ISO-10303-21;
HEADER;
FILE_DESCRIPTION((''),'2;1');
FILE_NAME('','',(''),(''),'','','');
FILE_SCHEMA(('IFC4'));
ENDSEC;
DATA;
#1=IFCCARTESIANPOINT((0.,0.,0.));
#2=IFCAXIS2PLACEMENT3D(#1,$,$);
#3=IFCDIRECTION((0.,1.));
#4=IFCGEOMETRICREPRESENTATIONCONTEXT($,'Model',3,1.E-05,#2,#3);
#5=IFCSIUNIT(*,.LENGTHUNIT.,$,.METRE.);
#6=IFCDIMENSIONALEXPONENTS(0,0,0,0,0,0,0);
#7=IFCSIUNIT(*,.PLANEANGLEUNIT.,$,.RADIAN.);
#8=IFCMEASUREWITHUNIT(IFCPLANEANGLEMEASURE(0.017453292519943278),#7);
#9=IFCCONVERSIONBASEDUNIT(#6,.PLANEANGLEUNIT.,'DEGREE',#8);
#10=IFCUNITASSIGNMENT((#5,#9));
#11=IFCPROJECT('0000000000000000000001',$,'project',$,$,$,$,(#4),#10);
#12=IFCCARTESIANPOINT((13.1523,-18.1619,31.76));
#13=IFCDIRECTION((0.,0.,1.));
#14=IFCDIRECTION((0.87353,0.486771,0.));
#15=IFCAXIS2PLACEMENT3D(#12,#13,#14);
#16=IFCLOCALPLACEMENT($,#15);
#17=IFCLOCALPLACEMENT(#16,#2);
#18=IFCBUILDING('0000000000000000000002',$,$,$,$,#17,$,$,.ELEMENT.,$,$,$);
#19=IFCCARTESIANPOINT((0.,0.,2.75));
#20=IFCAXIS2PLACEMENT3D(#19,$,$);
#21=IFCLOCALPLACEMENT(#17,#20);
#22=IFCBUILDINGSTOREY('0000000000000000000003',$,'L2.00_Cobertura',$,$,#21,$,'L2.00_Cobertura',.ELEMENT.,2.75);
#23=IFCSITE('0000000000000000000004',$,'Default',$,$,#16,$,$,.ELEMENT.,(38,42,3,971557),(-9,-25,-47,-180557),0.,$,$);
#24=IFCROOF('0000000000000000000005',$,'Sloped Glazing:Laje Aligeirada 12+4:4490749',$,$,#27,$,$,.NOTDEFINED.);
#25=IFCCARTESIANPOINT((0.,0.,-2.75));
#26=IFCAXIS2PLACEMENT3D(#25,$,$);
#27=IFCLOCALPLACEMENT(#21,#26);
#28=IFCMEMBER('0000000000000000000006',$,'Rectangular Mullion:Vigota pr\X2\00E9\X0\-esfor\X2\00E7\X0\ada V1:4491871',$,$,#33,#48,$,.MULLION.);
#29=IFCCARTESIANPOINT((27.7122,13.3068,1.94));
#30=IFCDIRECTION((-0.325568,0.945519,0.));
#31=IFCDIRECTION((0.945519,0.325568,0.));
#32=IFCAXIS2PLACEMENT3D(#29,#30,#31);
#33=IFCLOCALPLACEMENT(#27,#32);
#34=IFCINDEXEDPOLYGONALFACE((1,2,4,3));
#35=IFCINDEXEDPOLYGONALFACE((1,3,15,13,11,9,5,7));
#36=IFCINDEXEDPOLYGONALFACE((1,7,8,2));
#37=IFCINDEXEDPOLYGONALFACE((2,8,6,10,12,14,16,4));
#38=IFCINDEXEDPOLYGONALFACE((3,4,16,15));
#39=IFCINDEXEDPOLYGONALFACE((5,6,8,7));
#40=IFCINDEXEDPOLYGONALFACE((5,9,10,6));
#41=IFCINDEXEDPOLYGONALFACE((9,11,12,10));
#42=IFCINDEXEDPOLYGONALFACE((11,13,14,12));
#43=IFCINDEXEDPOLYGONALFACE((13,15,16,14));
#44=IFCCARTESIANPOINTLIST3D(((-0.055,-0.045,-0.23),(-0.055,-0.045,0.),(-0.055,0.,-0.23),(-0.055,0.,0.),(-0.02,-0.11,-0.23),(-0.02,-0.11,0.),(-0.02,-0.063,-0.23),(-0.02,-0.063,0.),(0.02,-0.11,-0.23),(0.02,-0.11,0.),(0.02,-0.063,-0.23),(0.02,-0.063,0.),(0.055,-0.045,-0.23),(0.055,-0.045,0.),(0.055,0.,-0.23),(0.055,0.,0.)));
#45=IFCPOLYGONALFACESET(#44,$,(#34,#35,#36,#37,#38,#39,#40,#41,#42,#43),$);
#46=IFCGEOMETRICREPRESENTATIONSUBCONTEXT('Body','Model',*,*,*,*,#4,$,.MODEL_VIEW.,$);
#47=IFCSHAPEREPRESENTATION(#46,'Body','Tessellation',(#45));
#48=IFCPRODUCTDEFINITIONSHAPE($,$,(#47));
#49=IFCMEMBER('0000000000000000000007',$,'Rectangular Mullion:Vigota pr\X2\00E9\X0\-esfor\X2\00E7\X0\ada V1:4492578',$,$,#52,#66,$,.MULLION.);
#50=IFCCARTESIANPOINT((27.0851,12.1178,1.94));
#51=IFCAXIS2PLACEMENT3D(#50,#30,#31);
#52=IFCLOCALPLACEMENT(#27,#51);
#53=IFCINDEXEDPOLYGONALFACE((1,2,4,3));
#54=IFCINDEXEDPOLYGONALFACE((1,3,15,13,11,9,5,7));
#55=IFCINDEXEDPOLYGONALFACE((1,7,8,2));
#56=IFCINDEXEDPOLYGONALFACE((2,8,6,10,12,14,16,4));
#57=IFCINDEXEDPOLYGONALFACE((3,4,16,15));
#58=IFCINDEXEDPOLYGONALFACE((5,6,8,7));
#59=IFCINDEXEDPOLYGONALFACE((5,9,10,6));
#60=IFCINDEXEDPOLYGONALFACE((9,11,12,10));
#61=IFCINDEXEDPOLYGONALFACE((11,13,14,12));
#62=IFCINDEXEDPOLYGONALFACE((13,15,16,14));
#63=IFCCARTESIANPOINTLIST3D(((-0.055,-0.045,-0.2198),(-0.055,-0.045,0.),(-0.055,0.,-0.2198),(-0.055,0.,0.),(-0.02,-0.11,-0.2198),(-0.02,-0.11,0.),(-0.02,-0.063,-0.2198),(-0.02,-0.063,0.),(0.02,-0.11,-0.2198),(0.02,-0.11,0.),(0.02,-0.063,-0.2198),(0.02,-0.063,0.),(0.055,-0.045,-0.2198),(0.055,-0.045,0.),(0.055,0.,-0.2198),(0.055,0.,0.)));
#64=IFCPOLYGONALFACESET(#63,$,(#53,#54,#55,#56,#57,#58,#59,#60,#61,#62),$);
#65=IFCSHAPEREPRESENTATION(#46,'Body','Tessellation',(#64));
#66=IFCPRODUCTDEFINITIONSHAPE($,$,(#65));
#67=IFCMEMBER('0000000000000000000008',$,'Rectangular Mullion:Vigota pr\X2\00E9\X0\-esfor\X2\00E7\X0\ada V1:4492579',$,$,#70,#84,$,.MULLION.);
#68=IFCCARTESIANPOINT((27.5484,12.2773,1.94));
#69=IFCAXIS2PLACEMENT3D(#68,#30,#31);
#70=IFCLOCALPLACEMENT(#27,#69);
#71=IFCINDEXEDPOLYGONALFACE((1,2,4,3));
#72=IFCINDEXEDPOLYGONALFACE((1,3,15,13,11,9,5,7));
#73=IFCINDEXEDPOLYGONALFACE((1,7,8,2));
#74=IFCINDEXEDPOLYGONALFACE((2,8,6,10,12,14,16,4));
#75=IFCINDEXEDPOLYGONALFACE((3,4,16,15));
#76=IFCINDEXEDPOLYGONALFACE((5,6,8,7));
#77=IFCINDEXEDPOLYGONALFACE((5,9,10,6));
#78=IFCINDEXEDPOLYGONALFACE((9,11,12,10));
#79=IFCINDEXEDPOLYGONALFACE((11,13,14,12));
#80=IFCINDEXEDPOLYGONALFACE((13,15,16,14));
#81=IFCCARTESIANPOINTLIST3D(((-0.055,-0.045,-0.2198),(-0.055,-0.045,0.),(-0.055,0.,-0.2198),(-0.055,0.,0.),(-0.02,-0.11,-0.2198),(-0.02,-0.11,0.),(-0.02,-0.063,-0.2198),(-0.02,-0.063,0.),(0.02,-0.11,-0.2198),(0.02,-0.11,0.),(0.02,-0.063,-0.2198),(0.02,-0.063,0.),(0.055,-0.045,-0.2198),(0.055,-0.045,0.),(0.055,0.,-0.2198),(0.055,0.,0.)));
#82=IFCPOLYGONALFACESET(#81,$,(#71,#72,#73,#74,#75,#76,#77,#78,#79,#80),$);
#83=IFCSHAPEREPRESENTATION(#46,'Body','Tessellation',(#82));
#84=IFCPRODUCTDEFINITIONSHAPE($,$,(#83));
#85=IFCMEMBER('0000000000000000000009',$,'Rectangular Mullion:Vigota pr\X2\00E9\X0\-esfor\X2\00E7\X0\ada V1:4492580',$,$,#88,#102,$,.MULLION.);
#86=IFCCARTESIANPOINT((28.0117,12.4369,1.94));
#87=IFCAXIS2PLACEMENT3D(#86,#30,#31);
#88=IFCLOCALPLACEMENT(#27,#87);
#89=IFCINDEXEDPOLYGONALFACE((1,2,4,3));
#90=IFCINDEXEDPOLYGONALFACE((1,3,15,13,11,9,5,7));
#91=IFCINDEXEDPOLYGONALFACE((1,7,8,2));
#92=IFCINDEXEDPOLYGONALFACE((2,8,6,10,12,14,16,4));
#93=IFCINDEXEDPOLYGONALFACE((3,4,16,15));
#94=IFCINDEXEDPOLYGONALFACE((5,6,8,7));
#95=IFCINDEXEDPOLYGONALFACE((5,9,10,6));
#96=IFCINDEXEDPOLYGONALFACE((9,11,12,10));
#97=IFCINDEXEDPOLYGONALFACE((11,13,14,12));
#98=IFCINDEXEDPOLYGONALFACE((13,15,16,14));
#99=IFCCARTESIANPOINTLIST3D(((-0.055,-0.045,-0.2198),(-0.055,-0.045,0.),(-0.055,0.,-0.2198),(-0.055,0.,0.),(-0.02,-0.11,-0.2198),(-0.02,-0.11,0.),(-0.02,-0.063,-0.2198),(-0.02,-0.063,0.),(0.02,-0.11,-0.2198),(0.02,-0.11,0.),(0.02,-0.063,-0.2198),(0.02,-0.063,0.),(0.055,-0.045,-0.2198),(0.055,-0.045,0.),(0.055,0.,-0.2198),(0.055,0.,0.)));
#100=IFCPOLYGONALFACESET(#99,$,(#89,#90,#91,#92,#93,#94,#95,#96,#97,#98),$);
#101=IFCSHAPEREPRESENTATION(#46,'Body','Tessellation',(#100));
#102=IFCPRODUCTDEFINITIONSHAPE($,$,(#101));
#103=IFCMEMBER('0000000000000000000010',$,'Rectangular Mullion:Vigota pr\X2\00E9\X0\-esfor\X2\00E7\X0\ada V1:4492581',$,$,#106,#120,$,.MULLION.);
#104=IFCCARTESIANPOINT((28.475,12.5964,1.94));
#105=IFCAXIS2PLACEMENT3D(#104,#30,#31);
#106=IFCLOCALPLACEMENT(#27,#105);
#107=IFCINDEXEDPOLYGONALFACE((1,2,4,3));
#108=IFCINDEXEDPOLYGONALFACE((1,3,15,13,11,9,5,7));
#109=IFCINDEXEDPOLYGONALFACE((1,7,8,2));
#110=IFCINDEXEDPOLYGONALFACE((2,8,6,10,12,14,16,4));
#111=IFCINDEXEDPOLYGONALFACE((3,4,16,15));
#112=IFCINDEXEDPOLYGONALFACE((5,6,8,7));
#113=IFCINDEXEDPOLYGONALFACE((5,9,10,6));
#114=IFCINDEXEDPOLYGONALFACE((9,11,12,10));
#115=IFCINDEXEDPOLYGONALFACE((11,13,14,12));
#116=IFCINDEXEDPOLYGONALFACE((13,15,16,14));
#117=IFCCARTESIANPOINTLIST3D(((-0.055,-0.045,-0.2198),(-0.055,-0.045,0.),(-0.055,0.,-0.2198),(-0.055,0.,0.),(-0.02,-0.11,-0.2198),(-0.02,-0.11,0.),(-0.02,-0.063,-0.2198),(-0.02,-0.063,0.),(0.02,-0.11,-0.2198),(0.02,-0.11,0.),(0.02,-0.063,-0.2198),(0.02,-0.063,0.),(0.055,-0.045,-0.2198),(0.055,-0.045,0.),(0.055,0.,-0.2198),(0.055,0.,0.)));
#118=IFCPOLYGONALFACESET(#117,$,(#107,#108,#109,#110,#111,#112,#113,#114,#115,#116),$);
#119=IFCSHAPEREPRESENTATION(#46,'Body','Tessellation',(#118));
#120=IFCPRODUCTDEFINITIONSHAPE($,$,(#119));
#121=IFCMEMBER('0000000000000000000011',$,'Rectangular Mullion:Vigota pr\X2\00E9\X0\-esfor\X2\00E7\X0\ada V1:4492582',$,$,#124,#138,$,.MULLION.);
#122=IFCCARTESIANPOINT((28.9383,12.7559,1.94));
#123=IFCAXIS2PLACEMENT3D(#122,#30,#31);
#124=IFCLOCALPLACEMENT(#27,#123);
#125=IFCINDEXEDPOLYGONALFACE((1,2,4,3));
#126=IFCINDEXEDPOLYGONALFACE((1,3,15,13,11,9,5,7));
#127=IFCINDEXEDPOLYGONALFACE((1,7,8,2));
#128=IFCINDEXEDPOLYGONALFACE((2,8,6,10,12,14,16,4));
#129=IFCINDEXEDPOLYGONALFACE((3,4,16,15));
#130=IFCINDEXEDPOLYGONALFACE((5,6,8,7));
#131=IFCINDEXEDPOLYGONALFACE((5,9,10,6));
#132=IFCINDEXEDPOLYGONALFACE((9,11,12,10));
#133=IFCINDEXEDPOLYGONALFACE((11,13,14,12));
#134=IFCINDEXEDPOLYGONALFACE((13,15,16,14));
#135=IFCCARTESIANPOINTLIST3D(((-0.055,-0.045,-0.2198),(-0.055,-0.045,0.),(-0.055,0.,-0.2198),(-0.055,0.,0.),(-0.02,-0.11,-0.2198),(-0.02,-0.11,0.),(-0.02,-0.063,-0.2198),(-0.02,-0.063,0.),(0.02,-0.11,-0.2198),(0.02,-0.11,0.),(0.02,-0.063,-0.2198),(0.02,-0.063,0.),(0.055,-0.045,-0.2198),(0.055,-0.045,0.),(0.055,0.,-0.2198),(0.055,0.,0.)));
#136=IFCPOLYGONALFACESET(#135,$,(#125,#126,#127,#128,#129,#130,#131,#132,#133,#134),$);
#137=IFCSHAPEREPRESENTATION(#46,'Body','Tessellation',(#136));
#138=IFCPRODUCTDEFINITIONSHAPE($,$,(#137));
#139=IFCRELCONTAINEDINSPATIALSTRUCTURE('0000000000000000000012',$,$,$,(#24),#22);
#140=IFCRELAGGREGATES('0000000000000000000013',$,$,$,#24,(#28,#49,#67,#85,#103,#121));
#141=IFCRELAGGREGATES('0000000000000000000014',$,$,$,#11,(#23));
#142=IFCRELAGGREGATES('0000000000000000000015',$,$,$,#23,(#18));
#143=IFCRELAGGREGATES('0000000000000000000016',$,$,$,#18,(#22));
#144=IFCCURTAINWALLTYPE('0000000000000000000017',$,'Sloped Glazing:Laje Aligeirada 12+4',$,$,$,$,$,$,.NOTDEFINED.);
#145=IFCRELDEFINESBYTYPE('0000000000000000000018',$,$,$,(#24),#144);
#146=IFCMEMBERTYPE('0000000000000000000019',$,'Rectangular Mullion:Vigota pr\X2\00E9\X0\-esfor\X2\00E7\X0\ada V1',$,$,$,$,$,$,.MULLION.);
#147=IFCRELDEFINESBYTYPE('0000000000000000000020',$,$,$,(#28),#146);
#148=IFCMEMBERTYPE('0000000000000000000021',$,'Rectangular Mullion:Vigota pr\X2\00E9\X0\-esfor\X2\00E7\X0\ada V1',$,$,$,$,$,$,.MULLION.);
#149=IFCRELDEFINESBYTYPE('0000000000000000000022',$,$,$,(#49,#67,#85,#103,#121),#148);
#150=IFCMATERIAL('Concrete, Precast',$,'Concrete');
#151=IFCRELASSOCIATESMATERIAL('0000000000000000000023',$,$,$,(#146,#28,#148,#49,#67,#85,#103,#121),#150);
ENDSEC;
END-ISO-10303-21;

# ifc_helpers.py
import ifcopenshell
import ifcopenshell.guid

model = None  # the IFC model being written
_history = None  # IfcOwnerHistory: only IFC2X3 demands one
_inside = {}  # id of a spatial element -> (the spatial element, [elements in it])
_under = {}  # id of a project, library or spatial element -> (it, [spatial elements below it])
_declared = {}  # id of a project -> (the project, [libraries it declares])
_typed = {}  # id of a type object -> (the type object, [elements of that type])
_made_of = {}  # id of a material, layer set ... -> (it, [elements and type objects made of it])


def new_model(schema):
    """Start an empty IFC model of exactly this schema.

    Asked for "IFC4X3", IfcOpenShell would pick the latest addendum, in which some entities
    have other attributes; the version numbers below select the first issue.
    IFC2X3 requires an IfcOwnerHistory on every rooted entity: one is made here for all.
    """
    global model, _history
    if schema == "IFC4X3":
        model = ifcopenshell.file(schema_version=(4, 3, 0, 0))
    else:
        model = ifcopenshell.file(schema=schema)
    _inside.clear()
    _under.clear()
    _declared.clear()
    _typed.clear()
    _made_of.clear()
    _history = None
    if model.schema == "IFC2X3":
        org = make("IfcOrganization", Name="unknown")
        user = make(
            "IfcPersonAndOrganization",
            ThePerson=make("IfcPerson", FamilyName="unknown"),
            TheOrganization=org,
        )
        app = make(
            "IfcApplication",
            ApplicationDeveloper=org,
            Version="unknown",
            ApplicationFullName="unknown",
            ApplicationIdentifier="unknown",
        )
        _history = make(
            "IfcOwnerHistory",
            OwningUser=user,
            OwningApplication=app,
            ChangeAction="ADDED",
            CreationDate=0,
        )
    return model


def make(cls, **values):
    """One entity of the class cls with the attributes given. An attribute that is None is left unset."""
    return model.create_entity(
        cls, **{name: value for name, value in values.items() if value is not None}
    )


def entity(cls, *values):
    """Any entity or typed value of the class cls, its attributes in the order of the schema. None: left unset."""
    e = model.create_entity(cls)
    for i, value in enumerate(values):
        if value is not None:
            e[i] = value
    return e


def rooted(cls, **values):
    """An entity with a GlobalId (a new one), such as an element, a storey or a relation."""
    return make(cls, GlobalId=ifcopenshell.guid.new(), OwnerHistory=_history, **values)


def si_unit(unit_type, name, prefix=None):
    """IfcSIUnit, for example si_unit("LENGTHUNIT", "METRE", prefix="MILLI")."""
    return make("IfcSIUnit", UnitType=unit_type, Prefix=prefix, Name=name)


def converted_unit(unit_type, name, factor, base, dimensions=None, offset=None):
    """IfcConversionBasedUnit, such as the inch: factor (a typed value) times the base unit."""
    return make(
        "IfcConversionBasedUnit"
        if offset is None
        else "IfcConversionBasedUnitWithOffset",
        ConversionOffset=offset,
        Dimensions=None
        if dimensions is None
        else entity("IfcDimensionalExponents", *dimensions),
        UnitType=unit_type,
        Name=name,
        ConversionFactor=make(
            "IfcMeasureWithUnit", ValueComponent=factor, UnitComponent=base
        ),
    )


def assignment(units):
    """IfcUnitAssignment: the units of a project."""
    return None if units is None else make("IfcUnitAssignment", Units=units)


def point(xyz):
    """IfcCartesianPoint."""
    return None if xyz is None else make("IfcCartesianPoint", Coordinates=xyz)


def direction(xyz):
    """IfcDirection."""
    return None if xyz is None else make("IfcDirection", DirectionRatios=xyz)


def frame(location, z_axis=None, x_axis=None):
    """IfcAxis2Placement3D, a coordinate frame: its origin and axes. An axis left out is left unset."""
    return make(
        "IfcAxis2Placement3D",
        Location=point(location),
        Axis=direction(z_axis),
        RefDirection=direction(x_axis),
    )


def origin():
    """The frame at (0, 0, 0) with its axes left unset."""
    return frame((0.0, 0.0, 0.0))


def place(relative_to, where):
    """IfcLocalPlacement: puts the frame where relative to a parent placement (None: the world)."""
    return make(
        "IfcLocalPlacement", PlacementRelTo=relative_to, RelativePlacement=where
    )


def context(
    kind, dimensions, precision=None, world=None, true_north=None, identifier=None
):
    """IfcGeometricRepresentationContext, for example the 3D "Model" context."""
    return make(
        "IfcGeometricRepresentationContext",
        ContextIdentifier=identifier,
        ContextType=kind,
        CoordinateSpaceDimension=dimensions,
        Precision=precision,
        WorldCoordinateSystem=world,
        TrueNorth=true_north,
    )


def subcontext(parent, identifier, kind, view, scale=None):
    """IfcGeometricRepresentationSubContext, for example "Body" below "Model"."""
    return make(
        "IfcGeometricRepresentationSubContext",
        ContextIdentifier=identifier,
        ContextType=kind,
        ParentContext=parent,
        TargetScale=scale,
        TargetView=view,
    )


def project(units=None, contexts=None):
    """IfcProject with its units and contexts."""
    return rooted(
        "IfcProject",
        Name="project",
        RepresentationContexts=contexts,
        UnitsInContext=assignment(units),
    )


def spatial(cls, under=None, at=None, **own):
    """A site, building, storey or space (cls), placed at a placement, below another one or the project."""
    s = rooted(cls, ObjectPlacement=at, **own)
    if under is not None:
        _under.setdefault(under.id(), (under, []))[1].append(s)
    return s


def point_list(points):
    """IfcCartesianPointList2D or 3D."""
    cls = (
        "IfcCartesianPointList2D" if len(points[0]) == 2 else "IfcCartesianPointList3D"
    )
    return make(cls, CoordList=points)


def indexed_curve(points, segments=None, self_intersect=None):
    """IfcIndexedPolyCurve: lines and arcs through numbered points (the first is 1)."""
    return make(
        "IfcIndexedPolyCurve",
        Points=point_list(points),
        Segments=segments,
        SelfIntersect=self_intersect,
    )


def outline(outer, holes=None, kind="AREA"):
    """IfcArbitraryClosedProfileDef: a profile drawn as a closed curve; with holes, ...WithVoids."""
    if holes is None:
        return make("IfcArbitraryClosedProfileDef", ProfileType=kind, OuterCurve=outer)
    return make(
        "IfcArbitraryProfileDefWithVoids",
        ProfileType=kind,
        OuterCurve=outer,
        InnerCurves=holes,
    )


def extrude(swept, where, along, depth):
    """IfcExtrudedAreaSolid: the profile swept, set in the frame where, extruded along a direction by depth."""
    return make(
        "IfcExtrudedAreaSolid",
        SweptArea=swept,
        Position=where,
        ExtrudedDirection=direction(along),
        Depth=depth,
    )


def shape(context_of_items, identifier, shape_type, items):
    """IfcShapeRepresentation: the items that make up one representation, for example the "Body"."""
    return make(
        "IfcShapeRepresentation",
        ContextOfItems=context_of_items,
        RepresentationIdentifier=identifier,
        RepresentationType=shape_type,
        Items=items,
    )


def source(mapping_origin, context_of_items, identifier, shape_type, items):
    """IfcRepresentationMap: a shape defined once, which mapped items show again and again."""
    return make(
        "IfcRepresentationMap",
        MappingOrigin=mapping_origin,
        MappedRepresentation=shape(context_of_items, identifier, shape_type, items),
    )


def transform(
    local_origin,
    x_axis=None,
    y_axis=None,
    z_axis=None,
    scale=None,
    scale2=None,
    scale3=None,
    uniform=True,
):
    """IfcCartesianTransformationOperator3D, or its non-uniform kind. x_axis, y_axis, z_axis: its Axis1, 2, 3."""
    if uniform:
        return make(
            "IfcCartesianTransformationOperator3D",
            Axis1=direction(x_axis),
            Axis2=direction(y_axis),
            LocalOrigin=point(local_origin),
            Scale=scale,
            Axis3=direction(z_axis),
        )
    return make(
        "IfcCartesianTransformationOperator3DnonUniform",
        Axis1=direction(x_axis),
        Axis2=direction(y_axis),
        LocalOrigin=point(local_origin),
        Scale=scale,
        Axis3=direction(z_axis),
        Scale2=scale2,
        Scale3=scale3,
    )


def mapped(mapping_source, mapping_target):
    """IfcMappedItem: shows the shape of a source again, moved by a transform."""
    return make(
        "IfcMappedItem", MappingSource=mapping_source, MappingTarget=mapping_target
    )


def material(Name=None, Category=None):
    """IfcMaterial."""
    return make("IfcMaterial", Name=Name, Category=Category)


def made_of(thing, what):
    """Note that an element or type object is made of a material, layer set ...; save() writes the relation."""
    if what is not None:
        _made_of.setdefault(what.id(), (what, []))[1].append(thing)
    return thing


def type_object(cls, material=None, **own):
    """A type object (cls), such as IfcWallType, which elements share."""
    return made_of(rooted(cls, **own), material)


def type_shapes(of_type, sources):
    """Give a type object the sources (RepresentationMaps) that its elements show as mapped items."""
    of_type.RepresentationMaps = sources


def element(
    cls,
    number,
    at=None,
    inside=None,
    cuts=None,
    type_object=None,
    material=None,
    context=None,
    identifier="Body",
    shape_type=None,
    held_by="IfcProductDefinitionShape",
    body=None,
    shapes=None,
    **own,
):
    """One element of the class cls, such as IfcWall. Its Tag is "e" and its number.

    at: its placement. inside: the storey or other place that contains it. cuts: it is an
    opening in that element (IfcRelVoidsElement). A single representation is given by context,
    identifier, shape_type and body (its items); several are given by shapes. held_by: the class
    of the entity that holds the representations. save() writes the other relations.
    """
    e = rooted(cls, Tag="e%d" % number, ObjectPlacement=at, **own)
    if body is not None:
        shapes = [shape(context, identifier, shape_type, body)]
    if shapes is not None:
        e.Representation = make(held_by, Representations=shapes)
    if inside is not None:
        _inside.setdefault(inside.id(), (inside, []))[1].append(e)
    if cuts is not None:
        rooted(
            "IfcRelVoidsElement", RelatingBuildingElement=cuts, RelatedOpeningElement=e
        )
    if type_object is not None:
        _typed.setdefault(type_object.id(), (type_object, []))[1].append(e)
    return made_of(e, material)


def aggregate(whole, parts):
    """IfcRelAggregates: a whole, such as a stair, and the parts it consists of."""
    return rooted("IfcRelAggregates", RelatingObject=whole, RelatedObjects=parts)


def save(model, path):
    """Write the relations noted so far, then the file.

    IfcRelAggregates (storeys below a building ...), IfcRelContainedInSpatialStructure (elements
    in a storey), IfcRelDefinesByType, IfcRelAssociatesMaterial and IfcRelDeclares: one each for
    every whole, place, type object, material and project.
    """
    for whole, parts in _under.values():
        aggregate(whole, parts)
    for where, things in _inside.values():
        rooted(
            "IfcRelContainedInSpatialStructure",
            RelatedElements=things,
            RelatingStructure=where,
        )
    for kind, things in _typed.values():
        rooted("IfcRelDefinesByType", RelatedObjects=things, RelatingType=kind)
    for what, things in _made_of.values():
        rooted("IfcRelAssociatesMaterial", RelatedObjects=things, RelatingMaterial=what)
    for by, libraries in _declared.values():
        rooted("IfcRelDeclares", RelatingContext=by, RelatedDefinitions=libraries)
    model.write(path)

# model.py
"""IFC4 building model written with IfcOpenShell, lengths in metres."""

from ifc_helpers import new_model, entity, si_unit, converted_unit, direction, frame, origin, place, context, subcontext, project, spatial, indexed_curve, outline, extrude, source, transform, mapped, material, type_object, type_shapes, element, aggregate, save


model = new_model("IFC4")

# Units and contexts
model_context = context("Model", 3, precision=1e-05, world=origin(), true_north=direction((0.0, 1.0)))
body_context = subcontext(model_context, "Body", "Model", "MODEL_VIEW")
ifc_project = project(units=[si_unit("LENGTHUNIT", "METRE"), converted_unit("PLANEANGLEUNIT", "DEGREE", entity("IfcPlaneAngleMeasure", 0.017453292519943278), si_unit("PLANEANGLEUNIT", "RADIAN"), dimensions=[0, 0, 0, 0, 0, 0, 0])], contexts=[model_context])

# Site, building, storey
site_placement = place(None, frame((13.1523, -18.1619, 31.76), z_axis=(0.0, 0.0, 1.0), x_axis=(0.87353, 0.486771, 0.0)))
site = spatial("IfcSite", under=ifc_project, at=site_placement, Name="Default", CompositionType="ELEMENT", RefLatitude=(38, 42, 3, 971557), RefLongitude=(-9, -25, -47, -180557), RefElevation=0.0)
building_placement = place(site_placement, origin())
building = spatial("IfcBuilding", under=site, at=building_placement, CompositionType="ELEMENT")
storey_placement = place(building_placement, frame((0.0, 0.0, 2.75)))
storey = spatial("IfcBuildingStorey", under=building, at=storey_placement, Name="L2.00_Cobertura", LongName="L2.00_Cobertura", CompositionType="ELEMENT", Elevation=2.75)

# Roof, members
curtain_wall_type = type_object("IfcCurtainWallType", Name="Sloped Glazing:Laje Aligeirada 12+4", PredefinedType="NOTDEFINED")
roof_placement = place(storey_placement, frame((0.0, 0.0, -2.75)))
roof = element("IfcRoof", 1, at=roof_placement, inside=storey, type_object=curtain_wall_type, Name="Sloped Glazing:Laje Aligeirada 12+4:4490749", PredefinedType="NOTDEFINED")
ifc_material_1 = material(Name="Concrete, Precast", Category="Concrete")
member_type_1 = type_object("IfcMemberType", Name="Rectangular Mullion:Vigota pré-esforçada V1", PredefinedType="MULLION", material=ifc_material_1)
shared_shape_1 = source(origin(), body_context, "Body", "SweptSolid", [
    extrude(outline(indexed_curve([(-0.055, -0.0545), (0.055, -0.0545), (0.055, -0.0095), (0.02, 0.0085), (0.02, 0.0555), (-0.02, 0.0555), (-0.02, 0.0085), (-0.055, -0.0095), (-0.055, -0.0545)], self_intersect=False)), frame((0.0, -0.0545, -0.23), z_axis=(0.0, 0.0, 1.0), x_axis=(-1.0, 0.0, 0.0)), (0.0, 0.0, 1.0), 0.23),
])
type_shapes(member_type_1, [shared_shape_1])
member_1_placement = place(roof_placement, frame((27.7122, 13.3068, 1.94), z_axis=(-0.325568, 0.945519, 0.0), x_axis=(0.945519, 0.325568, 0.0)))
member_1 = element("IfcMember", 2, at=member_1_placement, type_object=member_type_1, material=ifc_material_1, Name="Rectangular Mullion:Vigota pré-esforçada V1:4491871", PredefinedType="MULLION", context=body_context, shape_type="MappedRepresentation", body=[
    mapped(shared_shape_1, transform((0.0, 0.0, 0.0), scale=1.0)),
])
member_type_2 = type_object("IfcMemberType", Name="Rectangular Mullion:Vigota pré-esforçada V1", PredefinedType="MULLION", material=ifc_material_1)
shared_shape_2 = source(origin(), body_context, "Body", "SweptSolid", [
    extrude(outline(indexed_curve([(-0.055, -0.0545), (0.055, -0.0545), (0.055, -0.0095), (0.02, 0.0085), (0.02, 0.0555), (-0.02, 0.0555), (-0.02, 0.0085), (-0.055, -0.0095), (-0.055, -0.0545)], self_intersect=False)), frame((0.0, -0.0545, -0.2198), z_axis=(0.0, 0.0, 1.0), x_axis=(-1.0, 0.0, 0.0)), (0.0, 0.0, 1.0), 0.2198),
])
type_shapes(member_type_2, [shared_shape_2])
member_2_placement = place(roof_placement, frame((27.0851, 12.1178, 1.94), z_axis=(-0.325568, 0.945519, 0.0), x_axis=(0.945519, 0.325568, 0.0)))
member_2 = element("IfcMember", 3, at=member_2_placement, type_object=member_type_2, material=ifc_material_1, Name="Rectangular Mullion:Vigota pré-esforçada V1:4492578", PredefinedType="MULLION", context=body_context, shape_type="MappedRepresentation", body=[
    mapped(shared_shape_2, transform((0.0, 0.0, 0.0), scale=1.0)),
])
member_3_placement = place(roof_placement, frame((27.5484, 12.2773, 1.94), z_axis=(-0.325568, 0.945519, 0.0), x_axis=(0.945519, 0.325568, 0.0)))
member_3 = element("IfcMember", 4, at=member_3_placement, type_object=member_type_2, material=ifc_material_1, Name="Rectangular Mullion:Vigota pré-esforçada V1:4492579", PredefinedType="MULLION", context=body_context, shape_type="MappedRepresentation", body=[
    mapped(shared_shape_2, transform((0.0, 0.0, 0.0), scale=1.0)),
])
member_4_placement = place(roof_placement, frame((28.0117, 12.4369, 1.94), z_axis=(-0.325568, 0.945519, 0.0), x_axis=(0.945519, 0.325568, 0.0)))
member_4 = element("IfcMember", 5, at=member_4_placement, type_object=member_type_2, material=ifc_material_1, Name="Rectangular Mullion:Vigota pré-esforçada V1:4492580", PredefinedType="MULLION", context=body_context, shape_type="MappedRepresentation", body=[
    mapped(shared_shape_2, transform((0.0, 0.0, 0.0), scale=1.0)),
])
member_5_placement = place(roof_placement, frame((28.475, 12.5964, 1.94), z_axis=(-0.325568, 0.945519, 0.0), x_axis=(0.945519, 0.325568, 0.0)))
member_5 = element("IfcMember", 6, at=member_5_placement, type_object=member_type_2, material=ifc_material_1, Name="Rectangular Mullion:Vigota pré-esforçada V1:4492581", PredefinedType="MULLION", context=body_context, shape_type="MappedRepresentation", body=[
    mapped(shared_shape_2, transform((0.0, 0.0, 0.0), scale=1.0)),
])
member_6_placement = place(roof_placement, frame((28.9383, 12.7559, 1.94), z_axis=(-0.325568, 0.945519, 0.0), x_axis=(0.945519, 0.325568, 0.0)))
member_6 = element("IfcMember", 7, at=member_6_placement, type_object=member_type_2, material=ifc_material_1, Name="Rectangular Mullion:Vigota pré-esforçada V1:4492582", PredefinedType="MULLION", context=body_context, shape_type="MappedRepresentation", body=[
    mapped(shared_shape_2, transform((0.0, 0.0, 0.0), scale=1.0)),
])
aggregate(roof, [member_1, member_2, member_3, member_4, member_5, member_6])

save(model, "model.ifc")
